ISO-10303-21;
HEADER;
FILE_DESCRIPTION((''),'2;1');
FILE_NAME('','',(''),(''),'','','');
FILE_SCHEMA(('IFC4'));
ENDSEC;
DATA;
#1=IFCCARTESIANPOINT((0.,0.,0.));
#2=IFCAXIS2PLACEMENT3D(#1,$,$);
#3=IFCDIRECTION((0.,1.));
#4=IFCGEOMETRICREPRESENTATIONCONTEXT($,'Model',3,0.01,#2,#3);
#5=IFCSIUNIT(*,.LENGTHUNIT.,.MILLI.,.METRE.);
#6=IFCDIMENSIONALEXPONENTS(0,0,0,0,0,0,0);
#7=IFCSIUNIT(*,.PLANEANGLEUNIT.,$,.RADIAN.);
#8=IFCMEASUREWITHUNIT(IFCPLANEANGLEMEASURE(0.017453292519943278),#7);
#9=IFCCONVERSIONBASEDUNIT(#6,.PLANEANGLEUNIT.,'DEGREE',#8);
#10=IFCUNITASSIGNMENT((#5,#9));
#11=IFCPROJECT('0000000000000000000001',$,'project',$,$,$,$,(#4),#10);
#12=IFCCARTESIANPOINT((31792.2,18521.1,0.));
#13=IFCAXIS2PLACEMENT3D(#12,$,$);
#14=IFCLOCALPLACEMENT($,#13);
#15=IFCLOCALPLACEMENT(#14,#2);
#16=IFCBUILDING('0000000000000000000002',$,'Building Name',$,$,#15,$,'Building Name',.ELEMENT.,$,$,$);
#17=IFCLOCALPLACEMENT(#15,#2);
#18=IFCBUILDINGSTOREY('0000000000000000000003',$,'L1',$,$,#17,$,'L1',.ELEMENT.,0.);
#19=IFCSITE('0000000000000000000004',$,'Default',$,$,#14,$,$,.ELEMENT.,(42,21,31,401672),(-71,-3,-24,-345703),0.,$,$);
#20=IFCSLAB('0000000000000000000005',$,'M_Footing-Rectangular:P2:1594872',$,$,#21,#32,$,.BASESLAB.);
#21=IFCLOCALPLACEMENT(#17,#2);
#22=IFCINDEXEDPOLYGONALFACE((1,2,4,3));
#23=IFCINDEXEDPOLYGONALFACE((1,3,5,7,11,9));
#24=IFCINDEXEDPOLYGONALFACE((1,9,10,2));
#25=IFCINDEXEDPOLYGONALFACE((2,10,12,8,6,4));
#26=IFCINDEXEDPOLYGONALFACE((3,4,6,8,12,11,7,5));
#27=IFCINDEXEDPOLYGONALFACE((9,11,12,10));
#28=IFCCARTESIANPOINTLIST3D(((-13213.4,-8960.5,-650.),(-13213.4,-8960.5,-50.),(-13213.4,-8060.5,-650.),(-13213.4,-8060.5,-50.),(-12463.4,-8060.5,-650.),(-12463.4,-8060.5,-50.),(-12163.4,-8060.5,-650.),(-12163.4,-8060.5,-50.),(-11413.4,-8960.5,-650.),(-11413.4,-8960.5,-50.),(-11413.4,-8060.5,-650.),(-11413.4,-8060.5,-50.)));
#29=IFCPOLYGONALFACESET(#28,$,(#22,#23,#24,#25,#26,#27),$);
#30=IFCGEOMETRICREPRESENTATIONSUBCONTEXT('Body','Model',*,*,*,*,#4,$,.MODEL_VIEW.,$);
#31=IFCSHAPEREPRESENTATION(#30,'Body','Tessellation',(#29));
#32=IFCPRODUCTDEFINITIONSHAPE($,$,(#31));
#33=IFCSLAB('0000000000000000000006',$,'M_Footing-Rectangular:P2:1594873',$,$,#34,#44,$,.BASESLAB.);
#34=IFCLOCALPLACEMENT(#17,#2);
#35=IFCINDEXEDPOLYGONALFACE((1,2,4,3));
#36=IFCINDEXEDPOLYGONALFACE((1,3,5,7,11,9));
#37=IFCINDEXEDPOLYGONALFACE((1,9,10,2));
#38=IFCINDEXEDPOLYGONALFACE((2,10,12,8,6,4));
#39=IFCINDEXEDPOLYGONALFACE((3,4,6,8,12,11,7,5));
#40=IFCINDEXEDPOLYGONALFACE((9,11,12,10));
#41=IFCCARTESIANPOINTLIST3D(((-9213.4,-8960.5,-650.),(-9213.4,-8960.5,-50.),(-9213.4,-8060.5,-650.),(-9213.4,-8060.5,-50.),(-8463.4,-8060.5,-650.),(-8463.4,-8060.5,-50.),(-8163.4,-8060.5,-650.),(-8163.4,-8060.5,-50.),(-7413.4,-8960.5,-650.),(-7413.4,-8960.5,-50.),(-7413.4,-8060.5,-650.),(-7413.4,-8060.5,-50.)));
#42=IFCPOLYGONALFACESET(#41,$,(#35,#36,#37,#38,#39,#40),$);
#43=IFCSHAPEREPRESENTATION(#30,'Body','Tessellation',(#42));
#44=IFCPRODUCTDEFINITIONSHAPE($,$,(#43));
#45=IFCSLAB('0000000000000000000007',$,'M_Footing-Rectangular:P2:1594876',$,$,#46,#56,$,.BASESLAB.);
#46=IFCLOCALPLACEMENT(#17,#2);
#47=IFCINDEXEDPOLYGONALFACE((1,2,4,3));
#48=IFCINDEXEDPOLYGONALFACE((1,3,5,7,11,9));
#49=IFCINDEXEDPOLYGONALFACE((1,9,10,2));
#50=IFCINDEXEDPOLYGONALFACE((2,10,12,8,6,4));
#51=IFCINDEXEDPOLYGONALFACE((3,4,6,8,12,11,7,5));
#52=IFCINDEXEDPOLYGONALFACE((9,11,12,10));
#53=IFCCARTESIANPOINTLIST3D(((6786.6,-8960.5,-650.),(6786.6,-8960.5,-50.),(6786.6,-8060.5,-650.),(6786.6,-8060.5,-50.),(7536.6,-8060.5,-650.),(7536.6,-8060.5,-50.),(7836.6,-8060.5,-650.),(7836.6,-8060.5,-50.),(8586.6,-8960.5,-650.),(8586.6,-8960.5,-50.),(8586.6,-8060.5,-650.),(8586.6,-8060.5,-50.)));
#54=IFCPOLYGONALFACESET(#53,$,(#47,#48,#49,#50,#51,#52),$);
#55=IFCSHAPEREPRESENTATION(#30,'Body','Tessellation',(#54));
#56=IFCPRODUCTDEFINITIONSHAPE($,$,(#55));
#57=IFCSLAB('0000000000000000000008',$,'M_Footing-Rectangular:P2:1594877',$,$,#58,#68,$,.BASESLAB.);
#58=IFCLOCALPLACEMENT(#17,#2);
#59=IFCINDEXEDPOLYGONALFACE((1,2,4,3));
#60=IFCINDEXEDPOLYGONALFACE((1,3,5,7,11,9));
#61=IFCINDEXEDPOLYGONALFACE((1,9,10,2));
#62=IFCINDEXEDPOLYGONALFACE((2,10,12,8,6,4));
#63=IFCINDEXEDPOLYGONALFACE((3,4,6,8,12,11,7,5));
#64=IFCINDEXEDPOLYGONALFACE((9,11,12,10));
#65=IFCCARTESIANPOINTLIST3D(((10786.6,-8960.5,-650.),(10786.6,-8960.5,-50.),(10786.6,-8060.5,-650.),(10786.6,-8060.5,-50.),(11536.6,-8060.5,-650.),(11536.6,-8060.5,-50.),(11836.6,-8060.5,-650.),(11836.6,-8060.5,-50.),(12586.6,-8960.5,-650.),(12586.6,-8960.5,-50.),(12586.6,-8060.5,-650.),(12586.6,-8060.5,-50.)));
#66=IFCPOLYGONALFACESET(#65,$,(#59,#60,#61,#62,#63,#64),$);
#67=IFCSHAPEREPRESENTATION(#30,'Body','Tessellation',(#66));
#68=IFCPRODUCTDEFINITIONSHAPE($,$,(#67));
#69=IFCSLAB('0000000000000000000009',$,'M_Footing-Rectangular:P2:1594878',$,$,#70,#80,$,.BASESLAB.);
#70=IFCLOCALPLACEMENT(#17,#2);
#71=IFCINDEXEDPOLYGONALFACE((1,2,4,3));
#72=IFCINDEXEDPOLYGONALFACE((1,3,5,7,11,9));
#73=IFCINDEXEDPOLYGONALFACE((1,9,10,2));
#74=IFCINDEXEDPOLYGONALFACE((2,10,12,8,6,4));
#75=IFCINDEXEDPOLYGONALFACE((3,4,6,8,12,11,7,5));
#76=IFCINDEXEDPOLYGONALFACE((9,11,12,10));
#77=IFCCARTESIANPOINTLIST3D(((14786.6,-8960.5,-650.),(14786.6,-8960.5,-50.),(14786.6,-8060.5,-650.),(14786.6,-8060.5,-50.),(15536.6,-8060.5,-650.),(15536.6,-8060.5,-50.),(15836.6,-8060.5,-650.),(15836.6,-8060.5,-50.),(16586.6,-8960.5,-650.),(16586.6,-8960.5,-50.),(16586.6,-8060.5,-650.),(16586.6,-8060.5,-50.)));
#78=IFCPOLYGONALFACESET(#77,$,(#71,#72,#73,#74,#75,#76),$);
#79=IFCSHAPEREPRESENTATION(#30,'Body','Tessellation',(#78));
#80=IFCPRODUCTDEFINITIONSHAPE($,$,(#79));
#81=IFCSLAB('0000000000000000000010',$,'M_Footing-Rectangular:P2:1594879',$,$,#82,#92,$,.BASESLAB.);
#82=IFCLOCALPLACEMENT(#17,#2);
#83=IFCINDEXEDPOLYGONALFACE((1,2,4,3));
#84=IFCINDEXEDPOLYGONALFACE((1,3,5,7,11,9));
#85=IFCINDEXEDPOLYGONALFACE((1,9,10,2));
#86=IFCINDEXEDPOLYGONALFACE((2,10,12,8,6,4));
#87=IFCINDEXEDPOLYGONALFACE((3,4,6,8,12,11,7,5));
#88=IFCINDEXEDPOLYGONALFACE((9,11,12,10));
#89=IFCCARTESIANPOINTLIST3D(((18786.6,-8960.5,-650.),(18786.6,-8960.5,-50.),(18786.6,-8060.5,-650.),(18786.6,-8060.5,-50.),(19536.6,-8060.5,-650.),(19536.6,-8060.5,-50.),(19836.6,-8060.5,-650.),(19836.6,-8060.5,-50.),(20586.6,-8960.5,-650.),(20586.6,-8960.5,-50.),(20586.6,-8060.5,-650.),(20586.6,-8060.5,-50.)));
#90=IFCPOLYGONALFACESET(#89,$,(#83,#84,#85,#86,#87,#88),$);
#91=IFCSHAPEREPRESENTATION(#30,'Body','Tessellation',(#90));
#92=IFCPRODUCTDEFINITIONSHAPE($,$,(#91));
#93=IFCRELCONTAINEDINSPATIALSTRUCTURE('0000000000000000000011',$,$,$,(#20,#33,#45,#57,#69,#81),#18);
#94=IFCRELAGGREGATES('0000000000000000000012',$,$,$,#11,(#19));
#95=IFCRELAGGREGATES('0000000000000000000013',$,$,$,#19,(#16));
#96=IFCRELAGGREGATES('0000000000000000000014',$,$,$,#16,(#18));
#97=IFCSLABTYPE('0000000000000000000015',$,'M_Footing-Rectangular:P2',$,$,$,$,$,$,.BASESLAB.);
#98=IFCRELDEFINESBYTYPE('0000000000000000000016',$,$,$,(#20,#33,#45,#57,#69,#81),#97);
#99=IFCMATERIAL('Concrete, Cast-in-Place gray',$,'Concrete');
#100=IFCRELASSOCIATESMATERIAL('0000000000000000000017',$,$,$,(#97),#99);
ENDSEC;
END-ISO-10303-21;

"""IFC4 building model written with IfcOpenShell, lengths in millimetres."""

from ifc_helpers import new_model, entity, si_unit, converted_unit, direction, frame, origin, place, context, subcontext, project, spatial, indexed_curve, outline, extrude, material, type_object, element, save


model = new_model("IFC4")

# Units and contexts
model_context = context("Model", 3, precision=0.01, world=origin(), true_north=direction((0.0, 1.0)))
body_context = subcontext(model_context, "Body", "Model", "MODEL_VIEW")
ifc_project = project(units=[si_unit("LENGTHUNIT", "METRE", prefix="MILLI"), converted_unit("PLANEANGLEUNIT", "DEGREE", entity("IfcPlaneAngleMeasure", 0.017453292519943278), si_unit("PLANEANGLEUNIT", "RADIAN"), dimensions=[0, 0, 0, 0, 0, 0, 0])], contexts=[model_context])

# Site, building, storey
site_placement = place(None, frame((31792.2, 18521.1, 0.0)))
site = spatial("IfcSite", under=ifc_project, at=site_placement, Name="Default", CompositionType="ELEMENT", RefLatitude=(42, 21, 31, 401672), RefLongitude=(-71, -3, -24, -345703), RefElevation=0.0)
building_placement = place(site_placement, origin())
building = spatial("IfcBuilding", under=site, at=building_placement, Name="Building Name", LongName="Building Name", CompositionType="ELEMENT")
storey_placement = place(building_placement, origin())
storey = spatial("IfcBuildingStorey", under=building, at=storey_placement, Name="L1", LongName="L1", CompositionType="ELEMENT", Elevation=0.0)

# Shared definitions
ifc_material = material(Name="Concrete, Cast-in-Place gray", Category="Concrete")

# Slabs
slab_type_1 = type_object("IfcSlabType", Name="M_Footing-Rectangular:P2", PredefinedType="BASESLAB", material=ifc_material)
slab_1_placement = place(storey_placement, origin())
element("IfcSlab", 1, at=slab_1_placement, inside=storey, type_object=slab_type_1, Name="M_Footing-Rectangular:P2:1594872", PredefinedType="BASESLAB", context=body_context, shape_type="SweptSolid", body=[
    extrude(outline(indexed_curve([(-300.0, -900.0), (600.0, -900.0), (600.0, 900.0), (-300.0, 900.0), (-300.0, 150.0), (-300.0, -150.0), (-300.0, -900.0)], self_intersect=False)), frame((-12313.4, -8360.5, -650.0), z_axis=(0.0, 0.0, 1.0), x_axis=(0.0, -1.0, 0.0)), (0.0, 0.0, 1.0), 600.0),
])
slab_2_placement = place(storey_placement, origin())
element("IfcSlab", 2, at=slab_2_placement, inside=storey, type_object=slab_type_1, Name="M_Footing-Rectangular:P2:1594873", PredefinedType="BASESLAB", context=body_context, shape_type="SweptSolid", body=[
    extrude(outline(indexed_curve([(-300.0, -900.0), (600.0, -900.0), (600.0, 900.0), (-300.0, 900.0), (-300.0, 150.0), (-300.0, -150.0), (-300.0, -900.0)], self_intersect=False)), frame((-8313.4, -8360.5, -650.0), z_axis=(0.0, 0.0, 1.0), x_axis=(0.0, -1.0, 0.0)), (0.0, 0.0, 1.0), 600.0),
])
slab_3_placement = place(storey_placement, origin())
element("IfcSlab", 3, at=slab_3_placement, inside=storey, type_object=slab_type_1, Name="M_Footing-Rectangular:P2:1594876", PredefinedType="BASESLAB", context=body_context, shape_type="SweptSolid", body=[
    extrude(outline(indexed_curve([(-300.0, -900.0), (600.0, -900.0), (600.0, 900.0), (-300.0, 900.0), (-300.0, 150.0), (-300.0, -150.0), (-300.0, -900.0)], self_intersect=False)), frame((7686.6, -8360.5, -650.0), z_axis=(0.0, 0.0, 1.0), x_axis=(0.0, -1.0, 0.0)), (0.0, 0.0, 1.0), 600.0),
])
slab_4_placement = place(storey_placement, origin())
element("IfcSlab", 4, at=slab_4_placement, inside=storey, type_object=slab_type_1, Name="M_Footing-Rectangular:P2:1594877", PredefinedType="BASESLAB", context=body_context, shape_type="SweptSolid", body=[
    extrude(outline(indexed_curve([(-300.0, -900.0), (600.0, -900.0), (600.0, 900.0), (-300.0, 900.0), (-300.0, 150.0), (-300.0, -150.0), (-300.0, -900.0)], self_intersect=False)), frame((11686.6, -8360.5, -650.0), z_axis=(0.0, 0.0, 1.0), x_axis=(0.0, -1.0, 0.0)), (0.0, 0.0, 1.0), 600.0),
])
slab_5_placement = place(storey_placement, origin())
element("IfcSlab", 5, at=slab_5_placement, inside=storey, type_object=slab_type_1, Name="M_Footing-Rectangular:P2:1594878", PredefinedType="BASESLAB", context=body_context, shape_type="SweptSolid", body=[
    extrude(outline(indexed_curve([(-300.0, -900.0), (600.0, -900.0), (600.0, 900.0), (-300.0, 900.0), (-300.0, 150.0), (-300.0, -150.0), (-300.0, -900.0)], self_intersect=False)), frame((15686.6, -8360.5, -650.0), z_axis=(0.0, 0.0, 1.0), x_axis=(0.0, -1.0, 0.0)), (0.0, 0.0, 1.0), 600.0),
])
slab_6_placement = place(storey_placement, origin())
element("IfcSlab", 6, at=slab_6_placement, inside=storey, type_object=slab_type_1, Name="M_Footing-Rectangular:P2:1594879", PredefinedType="BASESLAB", context=body_context, shape_type="SweptSolid", body=[
    extrude(outline(indexed_curve([(-300.0, -900.0), (600.0, -900.0), (600.0, 900.0), (-300.0, 900.0), (-300.0, 150.0), (-300.0, -150.0), (-300.0, -900.0)], self_intersect=False)), frame((19686.6, -8360.5, -650.0), z_axis=(0.0, 0.0, 1.0), x_axis=(0.0, -1.0, 0.0)), (0.0, 0.0, 1.0), 600.0),
])

save(model, "model.ifc")
